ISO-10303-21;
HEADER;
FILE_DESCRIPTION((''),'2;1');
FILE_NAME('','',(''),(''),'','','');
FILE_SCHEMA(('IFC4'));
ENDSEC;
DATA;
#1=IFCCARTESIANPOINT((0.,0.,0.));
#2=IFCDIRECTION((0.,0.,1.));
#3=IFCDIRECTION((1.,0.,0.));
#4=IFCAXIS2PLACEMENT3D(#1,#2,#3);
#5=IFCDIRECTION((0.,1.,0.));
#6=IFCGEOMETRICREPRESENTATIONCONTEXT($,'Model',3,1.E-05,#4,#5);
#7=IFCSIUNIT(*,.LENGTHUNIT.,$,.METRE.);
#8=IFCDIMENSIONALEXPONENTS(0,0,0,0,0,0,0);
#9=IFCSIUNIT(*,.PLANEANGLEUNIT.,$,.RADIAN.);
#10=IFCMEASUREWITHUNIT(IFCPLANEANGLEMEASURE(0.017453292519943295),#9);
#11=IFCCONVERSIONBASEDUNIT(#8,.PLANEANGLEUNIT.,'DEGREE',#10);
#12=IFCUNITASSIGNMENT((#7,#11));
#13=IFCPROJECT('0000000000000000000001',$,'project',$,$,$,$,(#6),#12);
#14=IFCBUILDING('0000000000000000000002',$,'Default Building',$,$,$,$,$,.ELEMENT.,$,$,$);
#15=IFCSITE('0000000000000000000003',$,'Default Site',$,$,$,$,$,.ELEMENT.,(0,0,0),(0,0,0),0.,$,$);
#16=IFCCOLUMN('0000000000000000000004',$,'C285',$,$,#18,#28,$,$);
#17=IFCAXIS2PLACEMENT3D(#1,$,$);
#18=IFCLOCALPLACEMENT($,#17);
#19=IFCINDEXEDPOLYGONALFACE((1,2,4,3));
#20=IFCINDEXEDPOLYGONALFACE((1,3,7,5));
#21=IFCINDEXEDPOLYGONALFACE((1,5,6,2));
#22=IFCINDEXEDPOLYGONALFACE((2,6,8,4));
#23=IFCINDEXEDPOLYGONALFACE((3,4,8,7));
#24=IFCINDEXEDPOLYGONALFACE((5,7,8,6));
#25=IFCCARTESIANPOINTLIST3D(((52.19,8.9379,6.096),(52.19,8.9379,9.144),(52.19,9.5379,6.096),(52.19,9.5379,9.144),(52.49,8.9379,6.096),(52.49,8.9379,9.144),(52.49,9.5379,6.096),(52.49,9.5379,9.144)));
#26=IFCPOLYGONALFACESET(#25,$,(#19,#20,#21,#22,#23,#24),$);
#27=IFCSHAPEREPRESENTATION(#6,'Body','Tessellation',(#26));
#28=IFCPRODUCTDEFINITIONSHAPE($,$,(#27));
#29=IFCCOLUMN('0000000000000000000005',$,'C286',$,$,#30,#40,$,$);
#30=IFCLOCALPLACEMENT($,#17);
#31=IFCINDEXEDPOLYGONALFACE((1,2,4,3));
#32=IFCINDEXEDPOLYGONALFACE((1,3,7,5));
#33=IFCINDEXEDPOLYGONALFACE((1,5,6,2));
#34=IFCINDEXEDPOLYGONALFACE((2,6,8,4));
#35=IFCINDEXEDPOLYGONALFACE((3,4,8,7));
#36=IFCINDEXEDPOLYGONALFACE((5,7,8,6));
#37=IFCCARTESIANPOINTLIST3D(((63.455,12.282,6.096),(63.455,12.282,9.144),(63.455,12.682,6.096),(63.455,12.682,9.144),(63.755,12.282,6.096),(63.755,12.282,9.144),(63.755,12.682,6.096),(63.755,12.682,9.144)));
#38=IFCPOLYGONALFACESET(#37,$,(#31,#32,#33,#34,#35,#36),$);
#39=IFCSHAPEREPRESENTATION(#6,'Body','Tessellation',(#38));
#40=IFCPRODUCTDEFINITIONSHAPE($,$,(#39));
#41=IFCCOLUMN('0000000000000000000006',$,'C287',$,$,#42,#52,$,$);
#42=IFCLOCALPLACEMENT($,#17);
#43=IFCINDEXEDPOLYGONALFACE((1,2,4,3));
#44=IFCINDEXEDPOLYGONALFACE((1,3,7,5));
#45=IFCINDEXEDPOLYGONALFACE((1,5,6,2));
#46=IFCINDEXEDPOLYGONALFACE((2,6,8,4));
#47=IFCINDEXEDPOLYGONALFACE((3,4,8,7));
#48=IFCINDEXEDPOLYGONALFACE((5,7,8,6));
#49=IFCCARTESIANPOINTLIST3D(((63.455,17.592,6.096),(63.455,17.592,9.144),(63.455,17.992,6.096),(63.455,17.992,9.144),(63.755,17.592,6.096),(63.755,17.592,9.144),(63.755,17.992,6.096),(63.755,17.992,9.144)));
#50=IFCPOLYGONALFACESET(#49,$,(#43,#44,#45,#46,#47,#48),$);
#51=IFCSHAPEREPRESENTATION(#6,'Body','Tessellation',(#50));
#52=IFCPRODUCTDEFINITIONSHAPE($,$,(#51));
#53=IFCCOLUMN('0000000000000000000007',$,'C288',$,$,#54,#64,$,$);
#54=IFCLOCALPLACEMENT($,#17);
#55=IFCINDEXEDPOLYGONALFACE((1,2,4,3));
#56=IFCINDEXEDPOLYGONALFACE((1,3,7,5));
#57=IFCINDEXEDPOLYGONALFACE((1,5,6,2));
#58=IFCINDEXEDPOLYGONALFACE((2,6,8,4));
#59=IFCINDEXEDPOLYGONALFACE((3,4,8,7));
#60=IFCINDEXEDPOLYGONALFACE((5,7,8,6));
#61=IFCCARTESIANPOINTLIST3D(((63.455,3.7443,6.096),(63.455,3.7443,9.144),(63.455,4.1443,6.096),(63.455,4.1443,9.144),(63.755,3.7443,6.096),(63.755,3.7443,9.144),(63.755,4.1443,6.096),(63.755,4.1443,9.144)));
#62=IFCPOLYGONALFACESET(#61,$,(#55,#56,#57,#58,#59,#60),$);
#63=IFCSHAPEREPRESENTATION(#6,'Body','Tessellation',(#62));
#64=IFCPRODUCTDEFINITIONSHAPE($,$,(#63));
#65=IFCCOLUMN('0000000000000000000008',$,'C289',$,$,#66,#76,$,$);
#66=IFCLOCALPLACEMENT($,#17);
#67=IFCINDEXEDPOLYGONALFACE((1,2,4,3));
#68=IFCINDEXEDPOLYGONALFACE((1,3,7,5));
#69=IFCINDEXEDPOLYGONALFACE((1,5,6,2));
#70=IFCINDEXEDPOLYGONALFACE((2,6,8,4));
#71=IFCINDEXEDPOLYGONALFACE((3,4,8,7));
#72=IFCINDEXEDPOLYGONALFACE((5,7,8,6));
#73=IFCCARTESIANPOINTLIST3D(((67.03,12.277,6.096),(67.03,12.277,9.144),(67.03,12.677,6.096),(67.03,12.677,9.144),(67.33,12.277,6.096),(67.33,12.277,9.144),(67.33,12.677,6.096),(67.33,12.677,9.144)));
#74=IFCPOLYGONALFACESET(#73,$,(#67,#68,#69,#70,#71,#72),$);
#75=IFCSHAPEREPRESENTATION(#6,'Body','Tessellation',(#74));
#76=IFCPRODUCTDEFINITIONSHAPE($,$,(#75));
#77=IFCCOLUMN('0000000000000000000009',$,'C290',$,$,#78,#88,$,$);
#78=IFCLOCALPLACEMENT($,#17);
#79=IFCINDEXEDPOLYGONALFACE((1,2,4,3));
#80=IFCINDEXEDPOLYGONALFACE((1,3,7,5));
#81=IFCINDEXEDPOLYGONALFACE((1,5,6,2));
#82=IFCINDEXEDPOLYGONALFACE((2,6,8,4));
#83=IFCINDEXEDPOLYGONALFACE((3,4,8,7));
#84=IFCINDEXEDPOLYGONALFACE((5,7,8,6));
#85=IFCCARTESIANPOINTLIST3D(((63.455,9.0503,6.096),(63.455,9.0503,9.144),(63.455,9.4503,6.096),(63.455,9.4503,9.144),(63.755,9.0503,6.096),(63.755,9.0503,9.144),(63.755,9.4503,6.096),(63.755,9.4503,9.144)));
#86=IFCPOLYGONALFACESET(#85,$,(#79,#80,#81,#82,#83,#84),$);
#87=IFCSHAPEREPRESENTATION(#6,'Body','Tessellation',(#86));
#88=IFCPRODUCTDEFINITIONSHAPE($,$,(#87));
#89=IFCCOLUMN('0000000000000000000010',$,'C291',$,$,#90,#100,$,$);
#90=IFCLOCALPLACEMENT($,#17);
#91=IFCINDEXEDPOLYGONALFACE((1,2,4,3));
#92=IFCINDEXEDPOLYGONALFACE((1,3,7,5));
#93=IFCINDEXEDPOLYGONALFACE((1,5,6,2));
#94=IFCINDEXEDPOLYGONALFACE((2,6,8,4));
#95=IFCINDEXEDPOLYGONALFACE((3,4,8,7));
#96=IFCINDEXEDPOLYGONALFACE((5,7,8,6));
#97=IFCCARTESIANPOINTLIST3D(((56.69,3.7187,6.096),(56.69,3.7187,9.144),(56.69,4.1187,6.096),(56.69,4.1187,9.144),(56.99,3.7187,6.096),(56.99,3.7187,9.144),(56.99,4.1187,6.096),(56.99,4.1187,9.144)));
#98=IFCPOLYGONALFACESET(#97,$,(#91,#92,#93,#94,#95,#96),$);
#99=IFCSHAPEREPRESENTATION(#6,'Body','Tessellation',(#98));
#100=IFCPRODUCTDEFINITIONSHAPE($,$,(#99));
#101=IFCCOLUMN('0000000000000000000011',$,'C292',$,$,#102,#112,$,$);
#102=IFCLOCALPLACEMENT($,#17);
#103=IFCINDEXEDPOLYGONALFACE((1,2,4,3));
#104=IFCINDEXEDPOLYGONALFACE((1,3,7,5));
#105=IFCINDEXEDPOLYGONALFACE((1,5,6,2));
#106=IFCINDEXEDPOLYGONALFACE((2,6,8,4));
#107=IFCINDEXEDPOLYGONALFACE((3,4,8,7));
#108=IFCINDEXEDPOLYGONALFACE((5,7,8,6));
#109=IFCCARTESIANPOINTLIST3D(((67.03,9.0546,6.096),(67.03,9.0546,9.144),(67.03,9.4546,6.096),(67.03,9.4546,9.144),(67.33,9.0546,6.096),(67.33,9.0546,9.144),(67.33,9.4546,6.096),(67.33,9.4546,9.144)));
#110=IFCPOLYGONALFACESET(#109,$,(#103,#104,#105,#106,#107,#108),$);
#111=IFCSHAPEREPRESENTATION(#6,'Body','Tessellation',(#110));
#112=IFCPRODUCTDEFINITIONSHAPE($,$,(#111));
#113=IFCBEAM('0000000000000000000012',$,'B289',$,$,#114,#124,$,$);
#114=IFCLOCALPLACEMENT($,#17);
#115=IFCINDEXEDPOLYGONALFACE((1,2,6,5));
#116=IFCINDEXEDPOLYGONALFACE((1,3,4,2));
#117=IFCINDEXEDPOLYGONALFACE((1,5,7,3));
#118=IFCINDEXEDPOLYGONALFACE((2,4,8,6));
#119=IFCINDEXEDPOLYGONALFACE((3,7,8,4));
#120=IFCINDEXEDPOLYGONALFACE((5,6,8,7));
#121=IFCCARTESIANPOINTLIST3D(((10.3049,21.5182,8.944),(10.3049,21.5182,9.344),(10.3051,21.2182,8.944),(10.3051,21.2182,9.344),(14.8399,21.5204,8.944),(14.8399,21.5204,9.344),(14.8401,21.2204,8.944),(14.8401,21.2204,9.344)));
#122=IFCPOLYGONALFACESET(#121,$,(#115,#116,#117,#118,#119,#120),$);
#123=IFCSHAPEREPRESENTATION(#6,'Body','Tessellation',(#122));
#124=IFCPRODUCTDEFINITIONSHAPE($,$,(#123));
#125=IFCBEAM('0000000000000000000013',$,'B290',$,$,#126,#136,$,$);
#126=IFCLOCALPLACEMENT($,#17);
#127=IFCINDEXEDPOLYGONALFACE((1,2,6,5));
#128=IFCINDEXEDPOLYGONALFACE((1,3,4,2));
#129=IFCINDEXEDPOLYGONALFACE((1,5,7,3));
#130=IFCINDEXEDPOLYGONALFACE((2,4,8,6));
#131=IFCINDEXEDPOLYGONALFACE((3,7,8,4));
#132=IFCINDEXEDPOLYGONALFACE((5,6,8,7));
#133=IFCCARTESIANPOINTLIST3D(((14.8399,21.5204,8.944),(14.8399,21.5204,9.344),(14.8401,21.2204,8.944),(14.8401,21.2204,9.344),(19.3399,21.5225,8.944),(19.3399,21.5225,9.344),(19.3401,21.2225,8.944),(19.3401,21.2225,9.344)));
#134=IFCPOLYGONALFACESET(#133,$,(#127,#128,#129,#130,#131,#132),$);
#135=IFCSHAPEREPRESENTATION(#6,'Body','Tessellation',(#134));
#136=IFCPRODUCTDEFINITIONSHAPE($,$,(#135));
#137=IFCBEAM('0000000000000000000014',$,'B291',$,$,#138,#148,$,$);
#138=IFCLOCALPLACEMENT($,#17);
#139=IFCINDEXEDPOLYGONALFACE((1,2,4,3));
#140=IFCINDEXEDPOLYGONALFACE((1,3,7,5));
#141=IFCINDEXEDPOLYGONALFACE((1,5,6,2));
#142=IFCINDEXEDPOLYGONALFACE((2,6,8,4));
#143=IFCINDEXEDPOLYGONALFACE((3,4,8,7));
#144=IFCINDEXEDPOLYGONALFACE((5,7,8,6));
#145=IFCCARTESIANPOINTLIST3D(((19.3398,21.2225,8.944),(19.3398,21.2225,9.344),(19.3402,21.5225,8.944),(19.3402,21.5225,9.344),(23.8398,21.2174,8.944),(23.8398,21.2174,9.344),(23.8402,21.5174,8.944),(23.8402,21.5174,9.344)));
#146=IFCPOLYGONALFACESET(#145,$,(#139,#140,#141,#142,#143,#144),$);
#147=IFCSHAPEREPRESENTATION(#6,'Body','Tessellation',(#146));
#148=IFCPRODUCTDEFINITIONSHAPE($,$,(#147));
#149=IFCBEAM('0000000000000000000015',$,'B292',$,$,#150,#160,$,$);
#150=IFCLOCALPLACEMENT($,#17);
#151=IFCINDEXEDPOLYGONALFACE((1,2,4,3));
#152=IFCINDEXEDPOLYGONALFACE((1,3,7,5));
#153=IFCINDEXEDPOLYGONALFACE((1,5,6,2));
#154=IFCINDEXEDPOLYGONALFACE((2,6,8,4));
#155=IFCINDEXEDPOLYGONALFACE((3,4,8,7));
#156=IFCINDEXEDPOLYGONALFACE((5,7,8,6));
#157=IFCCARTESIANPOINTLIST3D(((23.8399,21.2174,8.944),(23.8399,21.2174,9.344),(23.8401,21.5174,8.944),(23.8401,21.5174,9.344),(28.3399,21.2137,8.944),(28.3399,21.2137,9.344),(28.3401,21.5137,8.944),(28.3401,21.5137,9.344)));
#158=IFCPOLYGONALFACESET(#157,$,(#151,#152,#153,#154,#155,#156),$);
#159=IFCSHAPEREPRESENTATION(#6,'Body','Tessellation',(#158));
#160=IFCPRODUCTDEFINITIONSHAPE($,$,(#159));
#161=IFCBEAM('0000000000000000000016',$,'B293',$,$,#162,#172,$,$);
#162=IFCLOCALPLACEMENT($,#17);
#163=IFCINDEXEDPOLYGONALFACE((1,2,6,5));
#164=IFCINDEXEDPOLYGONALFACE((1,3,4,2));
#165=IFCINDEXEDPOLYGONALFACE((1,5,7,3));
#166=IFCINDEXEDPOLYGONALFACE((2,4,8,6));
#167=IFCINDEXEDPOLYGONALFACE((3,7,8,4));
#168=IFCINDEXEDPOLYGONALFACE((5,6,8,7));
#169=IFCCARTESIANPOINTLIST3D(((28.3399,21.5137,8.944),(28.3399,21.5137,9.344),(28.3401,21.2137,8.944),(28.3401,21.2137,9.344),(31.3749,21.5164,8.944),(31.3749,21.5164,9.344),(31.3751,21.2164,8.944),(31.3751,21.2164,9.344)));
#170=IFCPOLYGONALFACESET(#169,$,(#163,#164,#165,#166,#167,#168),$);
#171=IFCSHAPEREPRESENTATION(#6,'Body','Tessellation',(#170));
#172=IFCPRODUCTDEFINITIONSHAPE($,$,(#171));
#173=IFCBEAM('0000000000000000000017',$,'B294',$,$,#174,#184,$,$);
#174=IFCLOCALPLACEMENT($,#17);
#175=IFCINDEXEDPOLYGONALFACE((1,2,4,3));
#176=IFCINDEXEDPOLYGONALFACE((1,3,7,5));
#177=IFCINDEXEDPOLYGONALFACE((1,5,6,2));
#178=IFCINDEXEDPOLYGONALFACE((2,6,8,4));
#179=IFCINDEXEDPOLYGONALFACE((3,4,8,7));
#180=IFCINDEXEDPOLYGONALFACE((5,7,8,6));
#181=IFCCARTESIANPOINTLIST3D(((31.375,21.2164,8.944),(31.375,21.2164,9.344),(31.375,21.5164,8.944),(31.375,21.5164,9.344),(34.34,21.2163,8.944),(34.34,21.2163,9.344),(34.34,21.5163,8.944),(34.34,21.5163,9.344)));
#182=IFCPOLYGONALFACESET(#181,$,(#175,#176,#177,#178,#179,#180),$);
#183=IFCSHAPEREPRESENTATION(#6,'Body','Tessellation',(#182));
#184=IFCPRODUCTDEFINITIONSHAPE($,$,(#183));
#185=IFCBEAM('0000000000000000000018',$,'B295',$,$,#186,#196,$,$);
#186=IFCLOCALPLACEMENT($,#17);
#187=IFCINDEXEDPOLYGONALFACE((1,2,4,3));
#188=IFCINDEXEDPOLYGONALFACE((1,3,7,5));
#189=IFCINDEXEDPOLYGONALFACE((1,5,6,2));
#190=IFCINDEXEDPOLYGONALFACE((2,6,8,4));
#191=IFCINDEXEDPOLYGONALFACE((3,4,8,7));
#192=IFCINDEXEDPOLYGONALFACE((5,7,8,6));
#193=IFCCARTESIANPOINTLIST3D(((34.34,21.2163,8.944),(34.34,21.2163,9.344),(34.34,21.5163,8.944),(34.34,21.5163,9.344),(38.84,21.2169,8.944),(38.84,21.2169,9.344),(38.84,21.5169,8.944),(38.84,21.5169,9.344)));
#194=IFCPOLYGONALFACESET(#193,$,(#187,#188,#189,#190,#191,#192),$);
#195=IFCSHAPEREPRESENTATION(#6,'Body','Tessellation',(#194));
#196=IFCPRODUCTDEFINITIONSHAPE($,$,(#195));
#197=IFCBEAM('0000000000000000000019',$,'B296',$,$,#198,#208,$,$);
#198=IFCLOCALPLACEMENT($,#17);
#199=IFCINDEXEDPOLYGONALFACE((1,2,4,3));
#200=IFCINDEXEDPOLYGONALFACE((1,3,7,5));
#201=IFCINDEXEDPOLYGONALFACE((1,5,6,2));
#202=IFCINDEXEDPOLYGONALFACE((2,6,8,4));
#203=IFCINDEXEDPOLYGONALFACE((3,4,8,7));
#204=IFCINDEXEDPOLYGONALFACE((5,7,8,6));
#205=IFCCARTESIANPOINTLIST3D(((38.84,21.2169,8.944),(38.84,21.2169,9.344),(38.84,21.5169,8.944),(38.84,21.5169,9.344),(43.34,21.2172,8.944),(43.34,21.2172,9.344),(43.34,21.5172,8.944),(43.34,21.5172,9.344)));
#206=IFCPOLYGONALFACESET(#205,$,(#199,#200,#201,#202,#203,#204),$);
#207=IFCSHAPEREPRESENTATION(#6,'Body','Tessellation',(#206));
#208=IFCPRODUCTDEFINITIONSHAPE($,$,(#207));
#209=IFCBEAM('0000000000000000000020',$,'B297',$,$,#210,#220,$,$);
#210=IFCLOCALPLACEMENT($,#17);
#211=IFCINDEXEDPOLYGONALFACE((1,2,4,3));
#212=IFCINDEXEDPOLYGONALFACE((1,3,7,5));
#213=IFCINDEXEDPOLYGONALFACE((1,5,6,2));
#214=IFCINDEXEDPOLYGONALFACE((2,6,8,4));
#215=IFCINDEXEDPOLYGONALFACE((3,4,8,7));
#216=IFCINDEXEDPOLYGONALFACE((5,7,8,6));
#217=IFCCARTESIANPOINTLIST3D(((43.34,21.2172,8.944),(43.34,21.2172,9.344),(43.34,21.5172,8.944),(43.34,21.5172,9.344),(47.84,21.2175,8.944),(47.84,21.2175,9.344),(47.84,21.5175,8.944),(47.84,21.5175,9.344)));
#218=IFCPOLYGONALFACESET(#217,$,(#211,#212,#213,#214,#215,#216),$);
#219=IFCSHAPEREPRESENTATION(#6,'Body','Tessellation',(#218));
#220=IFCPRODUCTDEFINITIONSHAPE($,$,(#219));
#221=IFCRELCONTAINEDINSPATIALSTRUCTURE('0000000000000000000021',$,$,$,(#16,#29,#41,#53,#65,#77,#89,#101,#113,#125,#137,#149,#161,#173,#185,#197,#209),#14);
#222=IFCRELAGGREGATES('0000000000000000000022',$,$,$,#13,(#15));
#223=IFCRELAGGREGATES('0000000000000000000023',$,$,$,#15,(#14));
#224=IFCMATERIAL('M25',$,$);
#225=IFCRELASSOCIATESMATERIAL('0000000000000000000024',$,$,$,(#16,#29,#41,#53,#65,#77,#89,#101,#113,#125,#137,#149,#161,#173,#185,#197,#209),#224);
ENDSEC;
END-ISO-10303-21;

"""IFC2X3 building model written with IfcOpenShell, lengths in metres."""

from ifc_helpers import new_model, entity, si_unit, converted_unit, direction, frame, frame_2d, origin_with_axes, place, context, project, spatial, rectangle, extrude, material, element, save


model = new_model("IFC2X3")

# Units and contexts
model_context = context("Model", 3, precision=1e-05, world=origin_with_axes(), true_north=direction((0.0, 1.0, 0.0)))
ifc_project = project(units=[si_unit("LENGTHUNIT", "METRE"), converted_unit("PLANEANGLEUNIT", "DEGREE", entity("IfcPlaneAngleMeasure", 0.017453292519943295), si_unit("PLANEANGLEUNIT", "RADIAN"), dimensions=[0, 0, 0, 0, 0, 0, 0])], contexts=[model_context])

# Site, building
site = spatial("IfcSite", under=ifc_project, Name="Default Site", CompositionType="ELEMENT", RefLatitude=(0, 0, 0), RefLongitude=(0, 0, 0), RefElevation=0.0)
building = spatial("IfcBuilding", under=site, Name="Default Building", CompositionType="ELEMENT")

# Columns
ifc_material = material(Name="M25")
placement = place(None, origin_with_axes())
element("IfcColumn", 1, at=placement, inside=building, material=ifc_material, Name="C285", context=model_context, shape_type="SweptSolid", body=[
    extrude(rectangle(XDim=0.3, YDim=0.6, at=frame_2d((0.0, 0.0), x_axis=(1.0, 0.0, 0.0))), frame((52.34, 9.2379, 6.096), z_axis=(0.0, 0.0, 1.0), x_axis=(1.0, 0.0, 0.0)), (0.0, 0.0, 1.0), 3.048),
])
element("IfcColumn", 2, at=placement, inside=building, material=ifc_material, Name="C286", context=model_context, shape_type="SweptSolid", body=[
    extrude(rectangle(XDim=0.3, YDim=0.4, at=frame_2d((0.0, 0.0), x_axis=(1.0, 0.0, 0.0))), frame((63.605, 12.482, 6.096), z_axis=(0.0, 0.0, 1.0), x_axis=(1.0, 0.0, 0.0)), (0.0, 0.0, 1.0), 3.048),
])
element("IfcColumn", 3, at=placement, inside=building, material=ifc_material, Name="C287", context=model_context, shape_type="SweptSolid", body=[
    extrude(rectangle(XDim=0.3, YDim=0.4, at=frame_2d((0.0, 0.0), x_axis=(1.0, 0.0, 0.0))), frame((63.605, 17.792, 6.096), z_axis=(0.0, 0.0, 1.0), x_axis=(1.0, 0.0, 0.0)), (0.0, 0.0, 1.0), 3.048),
])
element("IfcColumn", 4, at=placement, inside=building, material=ifc_material, Name="C288", context=model_context, shape_type="SweptSolid", body=[
    extrude(rectangle(XDim=0.3, YDim=0.4, at=frame_2d((0.0, 0.0), x_axis=(1.0, 0.0, 0.0))), frame((63.605, 3.9443, 6.096), z_axis=(0.0, 0.0, 1.0), x_axis=(1.0, 0.0, 0.0)), (0.0, 0.0, 1.0), 3.048),
])
element("IfcColumn", 5, at=placement, inside=building, material=ifc_material, Name="C289", context=model_context, shape_type="SweptSolid", body=[
    extrude(rectangle(XDim=0.3, YDim=0.4, at=frame_2d((0.0, 0.0), x_axis=(1.0, 0.0, 0.0))), frame((67.18, 12.477, 6.096), z_axis=(0.0, 0.0, 1.0), x_axis=(1.0, 0.0, 0.0)), (0.0, 0.0, 1.0), 3.048),
])
element("IfcColumn", 6, at=placement, inside=building, material=ifc_material, Name="C290", context=model_context, shape_type="SweptSolid", body=[
    extrude(rectangle(XDim=0.3, YDim=0.4, at=frame_2d((0.0, 0.0), x_axis=(1.0, 0.0, 0.0))), frame((63.605, 9.2503, 6.096), z_axis=(0.0, 0.0, 1.0), x_axis=(1.0, 0.0, 0.0)), (0.0, 0.0, 1.0), 3.048),
])
element("IfcColumn", 7, at=placement, inside=building, material=ifc_material, Name="C291", context=model_context, shape_type="SweptSolid", body=[
    extrude(rectangle(XDim=0.3, YDim=0.4, at=frame_2d((0.0, 0.0), x_axis=(1.0, 0.0, 0.0))), frame((56.84, 3.9187, 6.096), z_axis=(0.0, 0.0, 1.0), x_axis=(1.0, 0.0, 0.0)), (0.0, 0.0, 1.0), 3.048),
])
element("IfcColumn", 8, at=placement, inside=building, material=ifc_material, Name="C292", context=model_context, shape_type="SweptSolid", body=[
    extrude(rectangle(XDim=0.3, YDim=0.4, at=frame_2d((0.0, 0.0), x_axis=(1.0, 0.0, 0.0))), frame((67.18, 9.2546, 6.096), z_axis=(0.0, 0.0, 1.0), x_axis=(1.0, 0.0, 0.0)), (0.0, 0.0, 1.0), 3.048),
])

# Beams
element("IfcBeam", 9, at=placement, inside=building, material=ifc_material, Name="B289", context=model_context, shape_type="SweptSolid", body=[
    extrude(rectangle(XDim=0.3, YDim=0.4, at=frame_2d((0.0, 0.0), x_axis=(0.0, 1.0, 0.0))), frame((10.305, 21.3682, 9.144), z_axis=(1.0, 0.000476, 0.0), x_axis=(0.0, 0.0, -1.0)), (0.0, 0.0, 1.0), 4.535),
])
element("IfcBeam", 10, at=placement, inside=building, material=ifc_material, Name="B290", context=model_context, shape_type="SweptSolid", body=[
    extrude(rectangle(XDim=0.3, YDim=0.4, at=frame_2d((0.0, 0.0), x_axis=(0.0, 1.0, 0.0))), frame((14.84, 21.3704, 9.144), z_axis=(1.0, 0.000471, 0.0), x_axis=(0.0, 0.0, -1.0)), (0.0, 0.0, 1.0), 4.5),
])
element("IfcBeam", 11, at=placement, inside=building, material=ifc_material, Name="B291", context=model_context, shape_type="SweptSolid", body=[
    extrude(rectangle(XDim=0.3, YDim=0.4, at=frame_2d((0.0, 0.0), x_axis=(0.0, 1.0, 0.0))), frame((19.34, 21.3725, 9.144), z_axis=(0.999999, -0.001141, 0.0), x_axis=(0.0, 0.0, -1.0)), (0.0, 0.0, 1.0), 4.5),
])
element("IfcBeam", 12, at=placement, inside=building, material=ifc_material, Name="B292", context=model_context, shape_type="SweptSolid", body=[
    extrude(rectangle(XDim=0.3, YDim=0.4, at=frame_2d((0.0, 0.0), x_axis=(0.0, 1.0, 0.0))), frame((23.84, 21.3674, 9.144), z_axis=(1.0, -0.000812, 0.0), x_axis=(0.0, 0.0, -1.0)), (0.0, 0.0, 1.0), 4.5),
])
element("IfcBeam", 13, at=placement, inside=building, material=ifc_material, Name="B293", context=model_context, shape_type="SweptSolid", body=[
    extrude(rectangle(XDim=0.3, YDim=0.4, at=frame_2d((0.0, 0.0), x_axis=(0.0, 1.0, 0.0))), frame((28.34, 21.3637, 9.144), z_axis=(1.0, 0.000883, 0.0), x_axis=(0.0, 0.0, -1.0)), (0.0, 0.0, 1.0), 3.035),
])
element("IfcBeam", 14, at=placement, inside=building, material=ifc_material, Name="B294", context=model_context, shape_type="SweptSolid", body=[
    extrude(rectangle(XDim=0.3, YDim=0.4, at=frame_2d((0.0, 0.0), x_axis=(0.0, 1.0, 0.0))), frame((31.375, 21.3664, 9.144), z_axis=(1.0, -0.000016, 0.0), x_axis=(0.0, 0.0, -1.0)), (0.0, 0.0, 1.0), 2.965),
])
element("IfcBeam", 15, at=placement, inside=building, material=ifc_material, Name="B295", context=model_context, shape_type="SweptSolid", body=[
    extrude(rectangle(XDim=0.3, YDim=0.4, at=frame_2d((0.0, 0.0), x_axis=(0.0, 1.0, 0.0))), frame((34.34, 21.3663, 9.144), z_axis=(1.0, 0.000136, 0.0), x_axis=(0.0, 0.0, -1.0)), (0.0, 0.0, 1.0), 4.5),
])
element("IfcBeam", 16, at=placement, inside=building, material=ifc_material, Name="B296", context=model_context, shape_type="SweptSolid", body=[
    extrude(rectangle(XDim=0.3, YDim=0.4, at=frame_2d((0.0, 0.0), x_axis=(0.0, 1.0, 0.0))), frame((38.84, 21.3669, 9.144), z_axis=(1.0, 0.00005, 0.0), x_axis=(0.0, 0.0, -1.0)), (0.0, 0.0, 1.0), 4.5),
])
element("IfcBeam", 17, at=placement, inside=building, material=ifc_material, Name="B297", context=model_context, shape_type="SweptSolid", body=[
    extrude(rectangle(XDim=0.3, YDim=0.4, at=frame_2d((0.0, 0.0), x_axis=(0.0, 1.0, 0.0))), frame((43.34, 21.3672, 9.144), z_axis=(1.0, 0.000075, 0.0), x_axis=(0.0, 0.0, -1.0)), (0.0, 0.0, 1.0), 4.5),
])

save(model, "model.ifc")
